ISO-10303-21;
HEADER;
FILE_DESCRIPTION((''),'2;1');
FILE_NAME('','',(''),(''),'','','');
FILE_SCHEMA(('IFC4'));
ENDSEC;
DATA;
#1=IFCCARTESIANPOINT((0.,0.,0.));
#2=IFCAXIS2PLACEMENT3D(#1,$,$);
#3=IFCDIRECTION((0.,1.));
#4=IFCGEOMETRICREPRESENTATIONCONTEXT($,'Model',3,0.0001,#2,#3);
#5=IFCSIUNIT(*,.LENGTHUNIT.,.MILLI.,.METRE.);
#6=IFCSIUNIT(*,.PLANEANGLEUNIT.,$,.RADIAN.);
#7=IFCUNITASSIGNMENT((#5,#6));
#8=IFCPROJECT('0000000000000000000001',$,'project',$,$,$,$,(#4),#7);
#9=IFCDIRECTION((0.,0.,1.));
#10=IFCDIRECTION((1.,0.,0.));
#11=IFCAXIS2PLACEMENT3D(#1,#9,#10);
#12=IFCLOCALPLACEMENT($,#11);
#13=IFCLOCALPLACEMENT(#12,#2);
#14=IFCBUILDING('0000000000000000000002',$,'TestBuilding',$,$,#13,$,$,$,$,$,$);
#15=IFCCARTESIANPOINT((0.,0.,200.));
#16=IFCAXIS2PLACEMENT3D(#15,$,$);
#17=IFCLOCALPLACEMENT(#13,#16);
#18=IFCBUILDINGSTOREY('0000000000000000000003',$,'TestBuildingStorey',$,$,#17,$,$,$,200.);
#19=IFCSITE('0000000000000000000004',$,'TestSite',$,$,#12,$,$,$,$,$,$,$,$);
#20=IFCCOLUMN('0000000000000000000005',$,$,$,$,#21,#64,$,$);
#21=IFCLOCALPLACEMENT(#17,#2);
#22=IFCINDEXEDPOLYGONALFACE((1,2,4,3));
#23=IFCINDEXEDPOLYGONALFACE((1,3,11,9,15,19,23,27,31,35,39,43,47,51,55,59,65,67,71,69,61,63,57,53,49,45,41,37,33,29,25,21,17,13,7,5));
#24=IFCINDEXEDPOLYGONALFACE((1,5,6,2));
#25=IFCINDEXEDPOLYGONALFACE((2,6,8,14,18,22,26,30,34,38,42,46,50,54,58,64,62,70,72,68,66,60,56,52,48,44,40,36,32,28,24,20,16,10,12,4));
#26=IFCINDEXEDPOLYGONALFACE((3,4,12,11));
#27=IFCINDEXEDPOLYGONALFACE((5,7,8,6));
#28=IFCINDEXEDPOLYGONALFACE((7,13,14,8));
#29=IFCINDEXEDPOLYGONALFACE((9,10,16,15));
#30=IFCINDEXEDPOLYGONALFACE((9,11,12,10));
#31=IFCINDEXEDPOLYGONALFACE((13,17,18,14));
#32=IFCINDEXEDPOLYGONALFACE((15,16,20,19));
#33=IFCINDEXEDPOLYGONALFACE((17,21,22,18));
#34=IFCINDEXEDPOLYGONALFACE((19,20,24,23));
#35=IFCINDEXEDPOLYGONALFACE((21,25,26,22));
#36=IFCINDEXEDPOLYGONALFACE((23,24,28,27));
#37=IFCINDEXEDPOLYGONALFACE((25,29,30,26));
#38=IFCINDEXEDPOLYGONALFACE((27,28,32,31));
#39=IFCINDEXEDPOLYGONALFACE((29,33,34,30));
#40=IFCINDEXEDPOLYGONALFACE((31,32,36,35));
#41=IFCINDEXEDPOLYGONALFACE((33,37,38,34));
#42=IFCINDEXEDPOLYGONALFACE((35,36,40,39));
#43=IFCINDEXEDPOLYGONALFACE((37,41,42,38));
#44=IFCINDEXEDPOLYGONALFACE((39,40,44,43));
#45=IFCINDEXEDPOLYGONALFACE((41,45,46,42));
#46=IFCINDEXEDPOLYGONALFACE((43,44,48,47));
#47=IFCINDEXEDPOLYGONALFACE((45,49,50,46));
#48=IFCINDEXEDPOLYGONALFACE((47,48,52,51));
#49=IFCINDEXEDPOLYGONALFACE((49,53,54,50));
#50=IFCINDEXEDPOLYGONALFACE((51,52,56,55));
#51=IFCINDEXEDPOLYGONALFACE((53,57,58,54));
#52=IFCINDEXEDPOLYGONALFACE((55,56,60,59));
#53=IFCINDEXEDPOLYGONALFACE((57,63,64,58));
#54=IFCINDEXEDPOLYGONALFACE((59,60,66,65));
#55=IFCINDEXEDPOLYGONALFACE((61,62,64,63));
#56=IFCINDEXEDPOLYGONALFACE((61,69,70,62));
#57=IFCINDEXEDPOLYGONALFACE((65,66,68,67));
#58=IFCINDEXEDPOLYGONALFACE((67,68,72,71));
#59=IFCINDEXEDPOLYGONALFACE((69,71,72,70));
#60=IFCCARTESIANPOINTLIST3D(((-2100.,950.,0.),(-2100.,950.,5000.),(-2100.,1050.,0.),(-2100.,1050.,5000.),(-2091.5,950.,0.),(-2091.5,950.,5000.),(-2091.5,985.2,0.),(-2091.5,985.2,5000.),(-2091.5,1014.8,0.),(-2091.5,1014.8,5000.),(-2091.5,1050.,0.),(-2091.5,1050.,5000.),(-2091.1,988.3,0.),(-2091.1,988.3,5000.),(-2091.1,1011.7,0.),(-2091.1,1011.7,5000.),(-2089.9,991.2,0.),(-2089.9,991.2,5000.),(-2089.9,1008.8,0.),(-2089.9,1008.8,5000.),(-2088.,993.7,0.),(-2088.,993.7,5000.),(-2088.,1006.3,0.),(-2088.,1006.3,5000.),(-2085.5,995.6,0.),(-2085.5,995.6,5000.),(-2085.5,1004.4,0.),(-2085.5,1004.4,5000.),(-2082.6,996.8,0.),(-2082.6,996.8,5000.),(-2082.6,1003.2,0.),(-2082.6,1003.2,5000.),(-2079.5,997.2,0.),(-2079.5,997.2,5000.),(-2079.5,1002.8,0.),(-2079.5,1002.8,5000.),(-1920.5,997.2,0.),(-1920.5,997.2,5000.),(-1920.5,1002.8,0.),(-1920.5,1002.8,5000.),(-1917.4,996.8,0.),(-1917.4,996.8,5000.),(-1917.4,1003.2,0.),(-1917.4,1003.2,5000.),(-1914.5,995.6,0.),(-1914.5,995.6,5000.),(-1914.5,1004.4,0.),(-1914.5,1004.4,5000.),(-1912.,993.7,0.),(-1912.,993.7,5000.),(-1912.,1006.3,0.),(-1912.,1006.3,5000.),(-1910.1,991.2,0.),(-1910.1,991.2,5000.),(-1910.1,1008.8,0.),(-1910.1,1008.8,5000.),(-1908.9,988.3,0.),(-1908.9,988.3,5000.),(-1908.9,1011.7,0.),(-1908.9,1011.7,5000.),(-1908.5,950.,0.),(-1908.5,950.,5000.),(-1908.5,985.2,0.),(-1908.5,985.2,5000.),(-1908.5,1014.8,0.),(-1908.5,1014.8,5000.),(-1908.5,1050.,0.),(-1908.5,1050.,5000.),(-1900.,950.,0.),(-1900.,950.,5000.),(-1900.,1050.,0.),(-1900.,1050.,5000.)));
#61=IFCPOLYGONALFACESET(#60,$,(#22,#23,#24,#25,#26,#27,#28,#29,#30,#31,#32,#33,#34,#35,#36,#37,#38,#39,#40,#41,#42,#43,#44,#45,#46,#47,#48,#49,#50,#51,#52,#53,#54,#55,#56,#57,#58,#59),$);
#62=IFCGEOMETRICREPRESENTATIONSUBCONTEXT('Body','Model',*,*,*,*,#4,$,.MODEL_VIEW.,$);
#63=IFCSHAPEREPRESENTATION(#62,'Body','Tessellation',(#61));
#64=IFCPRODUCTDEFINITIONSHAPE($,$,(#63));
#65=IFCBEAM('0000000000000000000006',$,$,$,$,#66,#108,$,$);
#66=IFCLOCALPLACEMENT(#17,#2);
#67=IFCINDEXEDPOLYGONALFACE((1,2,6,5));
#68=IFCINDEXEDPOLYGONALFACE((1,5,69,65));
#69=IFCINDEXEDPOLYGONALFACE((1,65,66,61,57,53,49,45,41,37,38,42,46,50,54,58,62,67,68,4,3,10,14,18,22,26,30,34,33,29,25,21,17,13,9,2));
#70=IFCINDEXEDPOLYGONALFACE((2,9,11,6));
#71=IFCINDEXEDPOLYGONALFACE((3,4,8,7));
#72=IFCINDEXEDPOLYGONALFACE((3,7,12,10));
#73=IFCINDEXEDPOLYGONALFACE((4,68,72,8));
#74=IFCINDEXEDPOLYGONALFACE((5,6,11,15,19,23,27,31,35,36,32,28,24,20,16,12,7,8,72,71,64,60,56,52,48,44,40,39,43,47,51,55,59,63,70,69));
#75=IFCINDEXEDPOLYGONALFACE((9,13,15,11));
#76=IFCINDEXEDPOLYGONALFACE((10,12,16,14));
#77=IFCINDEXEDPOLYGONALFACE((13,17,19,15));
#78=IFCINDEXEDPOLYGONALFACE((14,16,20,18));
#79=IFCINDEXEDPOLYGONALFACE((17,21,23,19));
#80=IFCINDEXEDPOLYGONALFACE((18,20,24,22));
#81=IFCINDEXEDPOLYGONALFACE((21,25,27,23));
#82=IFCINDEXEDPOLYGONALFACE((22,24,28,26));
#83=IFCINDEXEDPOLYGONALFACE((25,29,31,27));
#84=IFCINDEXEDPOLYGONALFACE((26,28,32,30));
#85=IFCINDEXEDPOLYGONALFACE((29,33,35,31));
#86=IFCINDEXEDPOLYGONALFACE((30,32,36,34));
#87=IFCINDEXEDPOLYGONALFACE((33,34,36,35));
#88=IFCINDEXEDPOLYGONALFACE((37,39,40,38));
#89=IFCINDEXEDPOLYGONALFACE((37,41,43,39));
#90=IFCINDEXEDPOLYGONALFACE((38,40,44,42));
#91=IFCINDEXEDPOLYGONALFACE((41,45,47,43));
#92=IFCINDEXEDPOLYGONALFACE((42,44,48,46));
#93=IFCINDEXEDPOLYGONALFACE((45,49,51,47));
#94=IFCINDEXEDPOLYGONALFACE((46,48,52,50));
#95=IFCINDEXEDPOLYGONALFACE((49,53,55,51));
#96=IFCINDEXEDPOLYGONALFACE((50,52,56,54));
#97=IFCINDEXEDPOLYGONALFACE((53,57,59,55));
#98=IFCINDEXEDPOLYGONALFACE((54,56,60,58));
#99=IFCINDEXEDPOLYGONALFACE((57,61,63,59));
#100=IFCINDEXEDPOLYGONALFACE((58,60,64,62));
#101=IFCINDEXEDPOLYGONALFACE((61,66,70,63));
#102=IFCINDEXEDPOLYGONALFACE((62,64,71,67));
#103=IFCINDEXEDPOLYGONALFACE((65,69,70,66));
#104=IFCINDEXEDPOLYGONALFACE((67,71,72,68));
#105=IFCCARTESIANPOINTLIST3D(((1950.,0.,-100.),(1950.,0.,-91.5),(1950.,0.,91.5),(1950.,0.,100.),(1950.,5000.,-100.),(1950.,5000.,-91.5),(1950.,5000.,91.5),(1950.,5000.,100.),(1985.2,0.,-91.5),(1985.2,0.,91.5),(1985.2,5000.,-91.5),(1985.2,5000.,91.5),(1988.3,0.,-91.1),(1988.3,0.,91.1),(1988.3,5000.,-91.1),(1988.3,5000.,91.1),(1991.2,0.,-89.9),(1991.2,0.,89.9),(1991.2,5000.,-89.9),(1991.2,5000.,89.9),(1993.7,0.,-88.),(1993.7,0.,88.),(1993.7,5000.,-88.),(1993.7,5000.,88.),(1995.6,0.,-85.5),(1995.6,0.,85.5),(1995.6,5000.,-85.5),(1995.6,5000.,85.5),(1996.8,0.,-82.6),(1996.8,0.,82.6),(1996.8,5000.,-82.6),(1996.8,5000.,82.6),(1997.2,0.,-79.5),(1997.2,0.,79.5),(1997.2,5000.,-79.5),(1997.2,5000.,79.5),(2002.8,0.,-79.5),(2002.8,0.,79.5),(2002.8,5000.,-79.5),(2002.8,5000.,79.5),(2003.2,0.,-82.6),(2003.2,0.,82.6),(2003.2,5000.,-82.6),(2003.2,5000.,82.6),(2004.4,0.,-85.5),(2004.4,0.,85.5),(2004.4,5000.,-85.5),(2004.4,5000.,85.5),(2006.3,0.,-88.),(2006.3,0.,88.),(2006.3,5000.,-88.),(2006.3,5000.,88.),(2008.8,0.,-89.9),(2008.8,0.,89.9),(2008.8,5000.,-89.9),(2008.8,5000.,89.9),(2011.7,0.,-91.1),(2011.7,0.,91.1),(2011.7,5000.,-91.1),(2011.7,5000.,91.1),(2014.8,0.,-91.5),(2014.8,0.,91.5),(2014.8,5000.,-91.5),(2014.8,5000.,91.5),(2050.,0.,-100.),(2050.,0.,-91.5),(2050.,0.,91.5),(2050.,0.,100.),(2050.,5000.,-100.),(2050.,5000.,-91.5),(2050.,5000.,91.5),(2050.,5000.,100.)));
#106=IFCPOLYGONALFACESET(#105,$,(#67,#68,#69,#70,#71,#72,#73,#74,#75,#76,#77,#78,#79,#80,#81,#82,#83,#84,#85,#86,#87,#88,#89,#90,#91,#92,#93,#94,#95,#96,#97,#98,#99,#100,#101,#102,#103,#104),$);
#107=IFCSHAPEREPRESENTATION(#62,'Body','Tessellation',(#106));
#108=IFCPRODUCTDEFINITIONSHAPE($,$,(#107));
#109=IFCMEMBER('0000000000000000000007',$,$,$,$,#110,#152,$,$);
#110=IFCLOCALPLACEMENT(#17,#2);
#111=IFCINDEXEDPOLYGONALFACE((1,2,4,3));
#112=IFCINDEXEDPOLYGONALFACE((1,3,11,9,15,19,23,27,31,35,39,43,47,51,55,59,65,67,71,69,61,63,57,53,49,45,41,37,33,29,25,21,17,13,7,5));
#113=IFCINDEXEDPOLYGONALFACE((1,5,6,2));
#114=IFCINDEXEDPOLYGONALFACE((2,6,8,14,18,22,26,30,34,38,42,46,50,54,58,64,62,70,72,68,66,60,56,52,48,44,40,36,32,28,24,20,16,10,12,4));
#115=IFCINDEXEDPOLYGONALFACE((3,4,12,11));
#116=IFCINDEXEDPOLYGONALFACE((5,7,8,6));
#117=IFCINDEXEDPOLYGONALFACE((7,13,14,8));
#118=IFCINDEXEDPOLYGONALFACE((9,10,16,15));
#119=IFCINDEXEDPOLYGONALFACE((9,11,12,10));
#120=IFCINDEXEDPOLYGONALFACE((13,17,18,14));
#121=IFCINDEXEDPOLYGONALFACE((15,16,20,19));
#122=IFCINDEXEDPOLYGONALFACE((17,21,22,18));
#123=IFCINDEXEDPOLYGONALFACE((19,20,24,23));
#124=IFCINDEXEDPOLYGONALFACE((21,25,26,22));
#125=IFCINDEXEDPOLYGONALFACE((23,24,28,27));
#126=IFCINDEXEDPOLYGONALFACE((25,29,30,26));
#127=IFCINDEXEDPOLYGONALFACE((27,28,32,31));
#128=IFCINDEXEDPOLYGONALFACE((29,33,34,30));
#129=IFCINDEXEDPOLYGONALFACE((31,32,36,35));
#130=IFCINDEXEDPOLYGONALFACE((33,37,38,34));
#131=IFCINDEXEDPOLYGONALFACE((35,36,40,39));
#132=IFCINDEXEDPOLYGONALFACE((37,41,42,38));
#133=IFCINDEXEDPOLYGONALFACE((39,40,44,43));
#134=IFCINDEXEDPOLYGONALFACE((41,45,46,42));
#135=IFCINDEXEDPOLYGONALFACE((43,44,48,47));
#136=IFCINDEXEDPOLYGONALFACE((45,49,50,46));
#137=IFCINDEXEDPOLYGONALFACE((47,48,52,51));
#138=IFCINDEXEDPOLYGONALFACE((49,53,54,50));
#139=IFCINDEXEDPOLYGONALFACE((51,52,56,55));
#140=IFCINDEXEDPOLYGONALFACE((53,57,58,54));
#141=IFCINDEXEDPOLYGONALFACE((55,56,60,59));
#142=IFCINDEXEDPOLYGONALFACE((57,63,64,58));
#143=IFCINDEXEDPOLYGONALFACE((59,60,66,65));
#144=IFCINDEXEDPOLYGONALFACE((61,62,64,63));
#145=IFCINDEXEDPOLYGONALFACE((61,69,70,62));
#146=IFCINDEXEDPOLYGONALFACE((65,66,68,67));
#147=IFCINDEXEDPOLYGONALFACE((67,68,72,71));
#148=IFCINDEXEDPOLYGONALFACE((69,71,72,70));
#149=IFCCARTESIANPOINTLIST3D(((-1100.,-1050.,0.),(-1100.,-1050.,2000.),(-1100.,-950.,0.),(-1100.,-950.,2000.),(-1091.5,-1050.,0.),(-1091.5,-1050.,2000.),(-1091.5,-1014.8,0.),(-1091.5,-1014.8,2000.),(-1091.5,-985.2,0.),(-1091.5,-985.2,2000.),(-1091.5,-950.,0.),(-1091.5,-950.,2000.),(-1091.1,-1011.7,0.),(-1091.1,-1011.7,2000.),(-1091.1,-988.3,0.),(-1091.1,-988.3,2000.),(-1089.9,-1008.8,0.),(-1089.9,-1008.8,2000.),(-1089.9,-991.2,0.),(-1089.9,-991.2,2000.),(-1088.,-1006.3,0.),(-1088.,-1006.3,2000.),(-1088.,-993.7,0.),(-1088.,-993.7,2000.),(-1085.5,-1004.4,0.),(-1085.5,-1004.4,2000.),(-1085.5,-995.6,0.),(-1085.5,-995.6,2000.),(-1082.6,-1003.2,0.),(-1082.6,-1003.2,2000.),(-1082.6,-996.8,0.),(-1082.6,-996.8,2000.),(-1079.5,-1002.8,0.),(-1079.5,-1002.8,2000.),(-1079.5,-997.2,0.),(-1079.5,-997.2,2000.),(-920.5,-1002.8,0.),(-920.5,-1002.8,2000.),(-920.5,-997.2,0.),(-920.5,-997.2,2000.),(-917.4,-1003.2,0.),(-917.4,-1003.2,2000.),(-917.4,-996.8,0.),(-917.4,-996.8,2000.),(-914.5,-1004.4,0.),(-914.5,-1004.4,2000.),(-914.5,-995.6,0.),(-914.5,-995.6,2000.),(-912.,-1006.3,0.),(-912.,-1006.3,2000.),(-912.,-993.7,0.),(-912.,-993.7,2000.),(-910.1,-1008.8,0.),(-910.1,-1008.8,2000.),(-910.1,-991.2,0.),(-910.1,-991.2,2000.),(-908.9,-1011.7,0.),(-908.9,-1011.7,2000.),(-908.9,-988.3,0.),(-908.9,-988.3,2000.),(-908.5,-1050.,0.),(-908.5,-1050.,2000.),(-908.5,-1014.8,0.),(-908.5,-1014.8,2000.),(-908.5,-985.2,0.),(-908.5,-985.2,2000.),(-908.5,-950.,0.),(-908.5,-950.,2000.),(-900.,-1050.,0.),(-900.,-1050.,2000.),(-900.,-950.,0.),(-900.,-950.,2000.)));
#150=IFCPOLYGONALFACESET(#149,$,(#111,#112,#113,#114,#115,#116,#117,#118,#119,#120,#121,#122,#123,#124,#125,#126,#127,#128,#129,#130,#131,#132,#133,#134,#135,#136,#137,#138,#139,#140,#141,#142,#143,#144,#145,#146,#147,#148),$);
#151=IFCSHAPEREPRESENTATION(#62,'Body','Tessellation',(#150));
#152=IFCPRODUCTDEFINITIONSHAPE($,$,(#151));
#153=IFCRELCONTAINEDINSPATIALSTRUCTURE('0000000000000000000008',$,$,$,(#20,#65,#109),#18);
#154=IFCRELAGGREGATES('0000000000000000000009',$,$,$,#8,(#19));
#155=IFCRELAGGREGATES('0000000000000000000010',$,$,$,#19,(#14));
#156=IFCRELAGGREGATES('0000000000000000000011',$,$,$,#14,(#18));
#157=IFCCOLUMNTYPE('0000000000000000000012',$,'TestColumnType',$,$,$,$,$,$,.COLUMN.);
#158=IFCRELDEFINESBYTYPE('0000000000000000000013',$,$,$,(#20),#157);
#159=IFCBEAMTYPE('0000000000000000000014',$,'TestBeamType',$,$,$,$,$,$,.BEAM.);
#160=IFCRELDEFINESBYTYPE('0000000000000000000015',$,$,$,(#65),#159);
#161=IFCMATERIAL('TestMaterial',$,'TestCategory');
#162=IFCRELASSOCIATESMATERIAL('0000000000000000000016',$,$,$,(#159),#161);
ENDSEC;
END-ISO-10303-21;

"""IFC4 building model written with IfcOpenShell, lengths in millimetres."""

from ifc_helpers import new_model, si_unit, direction, frame, origin, origin_with_axes, place, context, subcontext, project, spatial, line, arc, indexed_curve, outline, extrude, material, material_profile, profile_set, type_object, element, save


model = new_model("IFC4")

# Units and contexts
model_context = context("Model", 3, precision=0.0001, world=origin(), true_north=direction((0.0, 1.0)))
body_context = subcontext(model_context, "Body", "Model", "MODEL_VIEW")
ifc_project = project(units=[si_unit("LENGTHUNIT", "METRE", prefix="MILLI"), si_unit("PLANEANGLEUNIT", "RADIAN")], contexts=[model_context])

# Site, building, storey
site_placement = place(None, origin_with_axes())
site = spatial("IfcSite", under=ifc_project, at=site_placement, Name="TestSite")
building_placement = place(site_placement, origin())
building = spatial("IfcBuilding", under=site, at=building_placement, Name="TestBuilding")
storey_placement = place(building_placement, frame((0.0, 0.0, 200.0)))
storey = spatial("IfcBuildingStorey", under=building, at=storey_placement, Name="TestBuildingStorey", Elevation=200.0)

# Column
column_type = type_object("IfcColumnType", Name="TestColumnType", PredefinedType="COLUMN")
column_placement = place(storey_placement, frame((-2000.0, 1000.0, 0.0), z_axis=(0.0, 0.0, 1.0), x_axis=(0.0, 1.0, 0.0)))
element("IfcColumn", 1, at=column_placement, inside=storey, type_object=column_type, context=body_context, shape_type="SweptSolid", body=[
    extrude(outline(indexed_curve([(2.8, -79.5), (2.8, 79.5), (6.3, 88.0), (14.8, 91.5), (50.0, 91.5), (50.0, 100.0), (-50.0, 100.0), (-50.0, 91.5), (-14.8, 91.5), (-6.3, 88.0), (-2.8, 79.5), (-2.8, -79.5), (-6.3, -88.0), (-14.8, -91.5), (-50.0, -91.5), (-50.0, -100.0), (50.0, -100.0), (50.0, -91.5), (14.8, -91.5), (6.3, -88.0)], segments=[line(1, 2), arc(2, 3, 4), line(4, 5), line(5, 6), line(6, 7), line(7, 8), line(8, 9), arc(9, 10, 11), line(11, 12), arc(12, 13, 14), line(14, 15), line(15, 16), line(16, 17), line(17, 18), line(18, 19), arc(19, 20, 1)])), None, (0.0, 0.0, 1.0), 5000.0),
])

# Beam
ifc_material = material(Name="TestMaterial", Category="TestCategory")
ifc_material_profile = material_profile(ifc_material, outline(indexed_curve([(2.8, -79.5), (2.8, 79.5), (6.3, 88.0), (14.8, 91.5), (50.0, 91.5), (50.0, 100.0), (-50.0, 100.0), (-50.0, 91.5), (-14.8, 91.5), (-6.3, 88.0), (-2.8, 79.5), (-2.8, -79.5), (-6.3, -88.0), (-14.8, -91.5), (-50.0, -91.5), (-50.0, -100.0), (50.0, -100.0), (50.0, -91.5), (14.8, -91.5), (6.3, -88.0)], segments=[line(1, 2), arc(2, 3, 4), line(4, 5), line(5, 6), line(6, 7), line(7, 8), line(8, 9), arc(9, 10, 11), line(11, 12), arc(12, 13, 14), line(14, 15), line(15, 16), line(16, 17), line(17, 18), line(18, 19), arc(19, 20, 1)])), Name="TestMaterialProfile")
ifc_profile_set = profile_set([ifc_material_profile], Name="TestMaterialProfileSet")
beam_type = type_object("IfcBeamType", Name="TestBeamType", PredefinedType="BEAM", material=ifc_profile_set)
beam_placement = place(storey_placement, frame((2000.0, 0.0, 0.0), z_axis=(0.0, 0.0, 1.0), x_axis=(0.0, 1.0, 0.0)))
element("IfcBeam", 2, at=beam_placement, inside=storey, type_object=beam_type, context=body_context, shape_type="SweptSolid", body=[
    extrude(outline(indexed_curve([(2.8, -79.5), (2.8, 79.5), (6.3, 88.0), (14.8, 91.5), (50.0, 91.5), (50.0, 100.0), (-50.0, 100.0), (-50.0, 91.5), (-14.8, 91.5), (-6.3, 88.0), (-2.8, 79.5), (-2.8, -79.5), (-6.3, -88.0), (-14.8, -91.5), (-50.0, -91.5), (-50.0, -100.0), (50.0, -100.0), (50.0, -91.5), (14.8, -91.5), (6.3, -88.0)], segments=[line(1, 2), arc(2, 3, 4), line(4, 5), line(5, 6), line(6, 7), line(7, 8), line(8, 9), arc(9, 10, 11), line(11, 12), arc(12, 13, 14), line(14, 15), line(15, 16), line(16, 17), line(17, 18), line(18, 19), arc(19, 20, 1)])), frame((0.0, 0.0, 0.0), z_axis=(1.0, 0.0, 0.0), x_axis=(0.0, -1.0, 0.0)), (0.0, 0.0, 1.0), 5000.0),
])

# Member
member_placement = place(storey_placement, frame((-1000.0, -1000.0, 0.0), z_axis=(0.0, 0.0, 1.0), x_axis=(0.0, -1.0, 0.0)))
element("IfcMember", 3, at=member_placement, inside=storey, context=body_context, shape_type="SweptSolid", body=[
    extrude(outline(indexed_curve([(2.8, -79.5), (2.8, 79.5), (6.3, 88.0), (14.8, 91.5), (50.0, 91.5), (50.0, 100.0), (-50.0, 100.0), (-50.0, 91.5), (-14.8, 91.5), (-6.3, 88.0), (-2.8, 79.5), (-2.8, -79.5), (-6.3, -88.0), (-14.8, -91.5), (-50.0, -91.5), (-50.0, -100.0), (50.0, -100.0), (50.0, -91.5), (14.8, -91.5), (6.3, -88.0)], segments=[line(1, 2), arc(2, 3, 4), line(4, 5), line(5, 6), line(6, 7), line(7, 8), line(8, 9), arc(9, 10, 11), line(11, 12), arc(12, 13, 14), line(14, 15), line(15, 16), line(16, 17), line(17, 18), line(18, 19), arc(19, 20, 1)])), None, (0.0, 0.0, 1.0), 2000.0),
])

save(model, "model.ifc")
